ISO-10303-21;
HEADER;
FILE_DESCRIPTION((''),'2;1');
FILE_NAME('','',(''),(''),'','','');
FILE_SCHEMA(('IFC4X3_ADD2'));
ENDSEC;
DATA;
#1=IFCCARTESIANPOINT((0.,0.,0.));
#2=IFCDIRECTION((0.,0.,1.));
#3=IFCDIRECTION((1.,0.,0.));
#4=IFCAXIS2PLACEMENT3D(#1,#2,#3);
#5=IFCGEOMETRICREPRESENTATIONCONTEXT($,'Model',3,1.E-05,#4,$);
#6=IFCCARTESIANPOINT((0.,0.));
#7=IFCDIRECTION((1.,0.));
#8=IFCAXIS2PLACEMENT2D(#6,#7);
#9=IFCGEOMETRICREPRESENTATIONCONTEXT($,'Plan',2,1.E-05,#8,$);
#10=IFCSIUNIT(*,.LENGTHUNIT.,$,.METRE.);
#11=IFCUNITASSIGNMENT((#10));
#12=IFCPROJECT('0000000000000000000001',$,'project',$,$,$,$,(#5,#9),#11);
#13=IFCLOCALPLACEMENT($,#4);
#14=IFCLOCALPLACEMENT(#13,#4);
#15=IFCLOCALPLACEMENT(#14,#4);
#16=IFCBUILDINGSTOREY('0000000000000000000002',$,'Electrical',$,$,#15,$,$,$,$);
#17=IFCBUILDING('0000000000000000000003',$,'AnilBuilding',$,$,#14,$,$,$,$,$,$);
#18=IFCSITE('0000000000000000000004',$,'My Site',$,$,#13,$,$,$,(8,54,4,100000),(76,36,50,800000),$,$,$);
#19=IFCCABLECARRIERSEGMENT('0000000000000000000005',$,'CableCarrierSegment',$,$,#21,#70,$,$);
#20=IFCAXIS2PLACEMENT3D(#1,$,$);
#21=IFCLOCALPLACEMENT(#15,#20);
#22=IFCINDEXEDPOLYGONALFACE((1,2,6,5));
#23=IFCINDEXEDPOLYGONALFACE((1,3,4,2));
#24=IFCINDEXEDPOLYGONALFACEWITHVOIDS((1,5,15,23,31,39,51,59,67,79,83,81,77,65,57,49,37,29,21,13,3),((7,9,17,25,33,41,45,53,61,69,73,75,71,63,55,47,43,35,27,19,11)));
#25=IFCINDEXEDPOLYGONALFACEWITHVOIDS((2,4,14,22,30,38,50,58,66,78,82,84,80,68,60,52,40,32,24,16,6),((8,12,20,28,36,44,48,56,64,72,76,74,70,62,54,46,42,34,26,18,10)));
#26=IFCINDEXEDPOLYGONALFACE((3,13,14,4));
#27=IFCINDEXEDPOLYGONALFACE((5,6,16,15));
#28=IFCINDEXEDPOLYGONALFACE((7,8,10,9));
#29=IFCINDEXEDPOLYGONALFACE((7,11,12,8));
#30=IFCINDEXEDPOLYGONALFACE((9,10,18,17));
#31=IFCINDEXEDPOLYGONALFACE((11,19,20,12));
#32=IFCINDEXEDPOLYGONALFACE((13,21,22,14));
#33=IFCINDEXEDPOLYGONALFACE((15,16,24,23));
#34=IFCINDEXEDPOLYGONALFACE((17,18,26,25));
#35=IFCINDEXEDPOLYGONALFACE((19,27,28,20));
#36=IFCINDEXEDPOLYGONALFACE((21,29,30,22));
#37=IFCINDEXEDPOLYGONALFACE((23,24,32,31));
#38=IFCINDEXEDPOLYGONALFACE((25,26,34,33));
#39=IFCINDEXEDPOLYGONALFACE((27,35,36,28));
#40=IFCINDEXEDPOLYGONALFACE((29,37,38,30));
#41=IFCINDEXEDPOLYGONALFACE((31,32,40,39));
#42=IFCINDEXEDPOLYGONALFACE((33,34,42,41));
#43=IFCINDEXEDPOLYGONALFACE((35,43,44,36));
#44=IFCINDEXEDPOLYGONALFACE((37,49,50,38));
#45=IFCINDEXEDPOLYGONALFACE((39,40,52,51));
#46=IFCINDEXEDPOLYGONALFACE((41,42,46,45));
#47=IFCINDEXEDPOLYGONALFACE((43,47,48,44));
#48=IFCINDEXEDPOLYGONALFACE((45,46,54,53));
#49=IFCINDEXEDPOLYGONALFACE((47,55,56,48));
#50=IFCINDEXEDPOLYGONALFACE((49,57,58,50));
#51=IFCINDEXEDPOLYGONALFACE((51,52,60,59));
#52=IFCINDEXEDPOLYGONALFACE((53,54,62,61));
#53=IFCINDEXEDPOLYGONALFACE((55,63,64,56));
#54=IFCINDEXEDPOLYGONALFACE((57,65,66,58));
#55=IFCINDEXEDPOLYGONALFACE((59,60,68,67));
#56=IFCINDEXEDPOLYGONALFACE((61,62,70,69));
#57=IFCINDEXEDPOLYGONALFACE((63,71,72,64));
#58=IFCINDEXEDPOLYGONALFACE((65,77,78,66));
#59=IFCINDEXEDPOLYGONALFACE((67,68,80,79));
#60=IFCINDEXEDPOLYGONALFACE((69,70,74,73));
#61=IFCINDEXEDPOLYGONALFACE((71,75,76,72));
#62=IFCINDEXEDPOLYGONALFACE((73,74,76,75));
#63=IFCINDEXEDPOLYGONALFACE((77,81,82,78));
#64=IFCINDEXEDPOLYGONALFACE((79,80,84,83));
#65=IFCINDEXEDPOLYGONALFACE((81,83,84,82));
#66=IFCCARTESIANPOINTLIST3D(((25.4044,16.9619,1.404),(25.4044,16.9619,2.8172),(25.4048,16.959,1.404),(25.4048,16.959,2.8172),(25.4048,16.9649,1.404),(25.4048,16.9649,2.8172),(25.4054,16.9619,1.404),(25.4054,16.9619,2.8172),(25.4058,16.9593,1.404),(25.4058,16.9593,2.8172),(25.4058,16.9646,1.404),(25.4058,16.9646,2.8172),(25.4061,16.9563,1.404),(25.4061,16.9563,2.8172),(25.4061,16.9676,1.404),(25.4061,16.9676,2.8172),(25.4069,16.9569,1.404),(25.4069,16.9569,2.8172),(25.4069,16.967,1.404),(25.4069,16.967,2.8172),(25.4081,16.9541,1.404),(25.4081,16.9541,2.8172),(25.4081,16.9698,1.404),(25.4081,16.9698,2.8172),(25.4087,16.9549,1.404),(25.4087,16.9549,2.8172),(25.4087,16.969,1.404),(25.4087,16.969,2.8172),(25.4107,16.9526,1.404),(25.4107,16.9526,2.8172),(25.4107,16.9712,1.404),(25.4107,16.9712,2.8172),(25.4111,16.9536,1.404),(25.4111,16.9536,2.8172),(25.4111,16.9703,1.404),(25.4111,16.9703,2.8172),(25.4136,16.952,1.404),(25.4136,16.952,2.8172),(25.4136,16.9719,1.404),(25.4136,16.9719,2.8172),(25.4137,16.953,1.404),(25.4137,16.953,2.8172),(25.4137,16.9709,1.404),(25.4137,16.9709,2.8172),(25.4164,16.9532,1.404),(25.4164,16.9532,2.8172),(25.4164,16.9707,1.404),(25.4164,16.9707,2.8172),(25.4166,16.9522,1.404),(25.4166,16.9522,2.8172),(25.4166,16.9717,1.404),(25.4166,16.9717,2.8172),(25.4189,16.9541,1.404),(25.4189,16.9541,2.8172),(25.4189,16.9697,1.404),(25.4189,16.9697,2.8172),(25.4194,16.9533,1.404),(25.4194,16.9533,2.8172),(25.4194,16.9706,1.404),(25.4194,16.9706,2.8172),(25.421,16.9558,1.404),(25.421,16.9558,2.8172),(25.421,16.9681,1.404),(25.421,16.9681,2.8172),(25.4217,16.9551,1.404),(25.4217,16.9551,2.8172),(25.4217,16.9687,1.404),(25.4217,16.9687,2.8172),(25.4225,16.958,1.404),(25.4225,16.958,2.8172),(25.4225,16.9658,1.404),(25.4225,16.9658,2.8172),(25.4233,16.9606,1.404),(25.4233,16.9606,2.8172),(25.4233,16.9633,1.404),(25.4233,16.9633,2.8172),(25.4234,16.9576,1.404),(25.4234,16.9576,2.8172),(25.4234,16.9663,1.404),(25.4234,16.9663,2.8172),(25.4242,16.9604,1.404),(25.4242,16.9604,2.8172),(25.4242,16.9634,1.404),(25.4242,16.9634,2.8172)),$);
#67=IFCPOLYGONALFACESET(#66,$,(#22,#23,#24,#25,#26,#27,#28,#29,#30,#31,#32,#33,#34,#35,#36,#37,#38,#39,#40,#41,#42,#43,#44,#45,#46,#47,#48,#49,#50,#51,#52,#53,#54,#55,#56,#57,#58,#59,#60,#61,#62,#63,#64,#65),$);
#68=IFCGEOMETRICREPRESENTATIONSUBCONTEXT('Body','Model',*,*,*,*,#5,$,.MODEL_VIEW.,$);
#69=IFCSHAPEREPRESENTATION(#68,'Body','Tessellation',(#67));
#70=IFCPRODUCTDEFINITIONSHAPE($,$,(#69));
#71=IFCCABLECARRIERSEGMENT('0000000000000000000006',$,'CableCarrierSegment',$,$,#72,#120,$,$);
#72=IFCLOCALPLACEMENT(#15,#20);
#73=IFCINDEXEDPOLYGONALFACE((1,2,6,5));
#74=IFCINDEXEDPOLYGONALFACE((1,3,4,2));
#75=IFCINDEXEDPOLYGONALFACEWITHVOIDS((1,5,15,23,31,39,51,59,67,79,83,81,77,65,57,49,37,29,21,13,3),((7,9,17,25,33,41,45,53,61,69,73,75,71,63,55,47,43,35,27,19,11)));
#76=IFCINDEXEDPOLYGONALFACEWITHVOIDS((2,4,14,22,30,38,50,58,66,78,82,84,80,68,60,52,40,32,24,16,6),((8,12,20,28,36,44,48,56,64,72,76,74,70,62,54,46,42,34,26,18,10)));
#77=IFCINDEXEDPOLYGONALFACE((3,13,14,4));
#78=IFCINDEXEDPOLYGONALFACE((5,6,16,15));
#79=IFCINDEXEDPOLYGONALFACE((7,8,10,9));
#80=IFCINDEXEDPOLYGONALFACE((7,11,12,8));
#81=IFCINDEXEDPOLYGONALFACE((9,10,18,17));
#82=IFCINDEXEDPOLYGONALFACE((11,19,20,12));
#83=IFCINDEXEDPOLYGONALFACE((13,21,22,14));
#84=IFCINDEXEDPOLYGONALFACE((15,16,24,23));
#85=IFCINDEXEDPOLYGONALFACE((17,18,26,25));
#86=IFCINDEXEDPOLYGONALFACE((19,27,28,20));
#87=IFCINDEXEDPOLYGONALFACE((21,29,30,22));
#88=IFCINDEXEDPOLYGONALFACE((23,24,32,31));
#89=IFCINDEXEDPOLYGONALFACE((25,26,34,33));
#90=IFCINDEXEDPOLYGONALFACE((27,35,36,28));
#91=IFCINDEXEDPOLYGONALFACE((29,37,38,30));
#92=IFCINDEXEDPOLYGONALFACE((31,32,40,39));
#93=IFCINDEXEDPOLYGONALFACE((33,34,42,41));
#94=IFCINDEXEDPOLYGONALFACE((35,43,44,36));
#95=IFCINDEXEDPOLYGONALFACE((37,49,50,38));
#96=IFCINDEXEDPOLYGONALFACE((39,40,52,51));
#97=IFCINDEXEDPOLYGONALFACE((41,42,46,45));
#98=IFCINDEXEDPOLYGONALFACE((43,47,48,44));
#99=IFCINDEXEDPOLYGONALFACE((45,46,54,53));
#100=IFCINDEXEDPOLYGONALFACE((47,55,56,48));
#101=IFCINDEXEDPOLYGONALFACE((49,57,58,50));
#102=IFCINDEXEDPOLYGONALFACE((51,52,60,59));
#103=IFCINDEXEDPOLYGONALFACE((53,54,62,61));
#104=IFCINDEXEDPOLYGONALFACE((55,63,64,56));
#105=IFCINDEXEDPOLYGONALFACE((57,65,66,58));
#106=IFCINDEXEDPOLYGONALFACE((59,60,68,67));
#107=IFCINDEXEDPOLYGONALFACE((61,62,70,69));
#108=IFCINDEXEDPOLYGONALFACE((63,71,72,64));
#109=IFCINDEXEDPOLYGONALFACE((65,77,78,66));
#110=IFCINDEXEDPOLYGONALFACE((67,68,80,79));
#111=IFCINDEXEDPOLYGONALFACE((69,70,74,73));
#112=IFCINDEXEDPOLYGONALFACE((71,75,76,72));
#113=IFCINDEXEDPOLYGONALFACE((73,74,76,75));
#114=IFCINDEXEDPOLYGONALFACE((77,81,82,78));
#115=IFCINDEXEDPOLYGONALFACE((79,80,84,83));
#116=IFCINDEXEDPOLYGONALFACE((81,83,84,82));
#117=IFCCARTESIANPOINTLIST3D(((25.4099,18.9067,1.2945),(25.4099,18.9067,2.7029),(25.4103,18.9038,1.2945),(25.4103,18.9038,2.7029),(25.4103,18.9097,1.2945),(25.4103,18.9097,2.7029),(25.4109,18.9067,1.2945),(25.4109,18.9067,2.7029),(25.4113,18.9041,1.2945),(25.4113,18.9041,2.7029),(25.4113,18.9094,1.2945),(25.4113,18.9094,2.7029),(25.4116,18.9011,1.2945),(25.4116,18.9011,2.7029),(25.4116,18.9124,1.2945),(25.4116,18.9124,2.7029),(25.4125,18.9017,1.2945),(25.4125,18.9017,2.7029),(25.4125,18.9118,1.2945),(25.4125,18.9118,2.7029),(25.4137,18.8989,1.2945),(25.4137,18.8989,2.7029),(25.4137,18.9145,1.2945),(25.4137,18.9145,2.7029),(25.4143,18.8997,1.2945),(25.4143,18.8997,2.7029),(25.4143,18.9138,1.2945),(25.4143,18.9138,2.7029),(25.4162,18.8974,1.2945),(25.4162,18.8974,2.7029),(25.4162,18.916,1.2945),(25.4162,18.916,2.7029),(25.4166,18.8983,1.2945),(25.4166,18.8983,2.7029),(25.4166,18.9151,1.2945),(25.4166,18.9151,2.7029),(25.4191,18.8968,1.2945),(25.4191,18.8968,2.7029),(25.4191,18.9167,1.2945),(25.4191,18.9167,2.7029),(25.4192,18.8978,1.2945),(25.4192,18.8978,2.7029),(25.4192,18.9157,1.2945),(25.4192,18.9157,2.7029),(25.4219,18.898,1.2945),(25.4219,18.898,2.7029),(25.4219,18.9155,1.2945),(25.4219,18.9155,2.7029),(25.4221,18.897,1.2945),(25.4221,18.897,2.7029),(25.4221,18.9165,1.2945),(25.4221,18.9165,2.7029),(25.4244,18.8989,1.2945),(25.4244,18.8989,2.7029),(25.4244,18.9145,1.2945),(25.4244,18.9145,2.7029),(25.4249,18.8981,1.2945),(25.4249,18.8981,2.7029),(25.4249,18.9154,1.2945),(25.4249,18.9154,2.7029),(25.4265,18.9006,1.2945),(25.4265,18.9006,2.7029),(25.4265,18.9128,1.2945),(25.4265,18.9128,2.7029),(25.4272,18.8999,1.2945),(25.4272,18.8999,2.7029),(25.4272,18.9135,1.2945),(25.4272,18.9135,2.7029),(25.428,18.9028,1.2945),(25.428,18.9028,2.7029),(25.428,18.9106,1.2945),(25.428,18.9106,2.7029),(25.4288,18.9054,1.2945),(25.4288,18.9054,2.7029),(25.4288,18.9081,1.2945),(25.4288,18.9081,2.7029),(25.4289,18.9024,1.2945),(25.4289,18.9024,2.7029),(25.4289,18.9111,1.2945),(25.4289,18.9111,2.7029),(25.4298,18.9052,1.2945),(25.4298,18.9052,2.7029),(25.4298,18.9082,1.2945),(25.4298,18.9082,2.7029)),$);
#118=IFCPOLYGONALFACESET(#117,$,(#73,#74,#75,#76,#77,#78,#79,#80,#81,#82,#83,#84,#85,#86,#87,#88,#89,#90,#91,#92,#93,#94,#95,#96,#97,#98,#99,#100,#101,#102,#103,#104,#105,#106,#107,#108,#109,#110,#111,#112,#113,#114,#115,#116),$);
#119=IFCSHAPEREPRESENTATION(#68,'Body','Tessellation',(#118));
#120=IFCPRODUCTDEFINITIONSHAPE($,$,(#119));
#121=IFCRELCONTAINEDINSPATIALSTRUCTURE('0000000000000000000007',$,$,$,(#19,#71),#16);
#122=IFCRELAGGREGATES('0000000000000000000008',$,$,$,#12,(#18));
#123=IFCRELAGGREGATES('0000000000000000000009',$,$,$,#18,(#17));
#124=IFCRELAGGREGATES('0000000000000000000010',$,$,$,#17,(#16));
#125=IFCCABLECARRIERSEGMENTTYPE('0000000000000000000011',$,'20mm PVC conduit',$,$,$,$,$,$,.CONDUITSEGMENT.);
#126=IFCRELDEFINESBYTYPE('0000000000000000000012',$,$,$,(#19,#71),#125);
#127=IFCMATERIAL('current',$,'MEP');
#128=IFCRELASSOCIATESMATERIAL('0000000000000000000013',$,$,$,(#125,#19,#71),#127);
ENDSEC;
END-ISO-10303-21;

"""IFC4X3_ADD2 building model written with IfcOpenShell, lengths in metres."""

from ifc_helpers import new_model, si_unit, frame, origin_with_axes, origin_2d_with_axis, place, context, subcontext, project, spatial, hollow_circle, extrude, material, material_profile, profile_set, profile_usage, type_object, element, save


model = new_model("IFC4X3_ADD2")

# Units and contexts
model_context = context("Model", 3, precision=1e-05, world=origin_with_axes())
plan_context = context("Plan", 2, precision=1e-05, world=origin_2d_with_axis())
body_context = subcontext(model_context, "Body", "Model", "MODEL_VIEW")
ifc_project = project(units=[si_unit("LENGTHUNIT", "METRE")], contexts=[model_context, plan_context])

# Site, building, storey
site_placement = place(None, origin_with_axes())
site = spatial("IfcSite", under=ifc_project, at=site_placement, Name="My Site", RefLatitude=(8, 54, 4, 100000), RefLongitude=(76, 36, 50, 800000))
building_placement = place(site_placement, origin_with_axes())
building = spatial("IfcBuilding", under=site, at=building_placement, Name="AnilBuilding")
storey_placement = place(building_placement, origin_with_axes())
storey = spatial("IfcBuildingStorey", under=building, at=storey_placement, Name="Electrical")

# Cable carrier segments
ifc_material = material(Name="current", Category="MEP")
ifc_material_profile_1 = material_profile(ifc_material, hollow_circle(Radius=0.01, WallThickness=0.001))
ifc_profile_set_1 = profile_set([ifc_material_profile_1], Name="current")
ifc_material_profile_2 = material_profile(ifc_material, hollow_circle(Radius=0.01, WallThickness=0.001))
ifc_profile_set_2 = profile_set([ifc_material_profile_2], Name="current")
cable_carrier_segment_type = type_object("IfcCableCarrierSegmentType", Name="20mm PVC conduit", PredefinedType="CONDUITSEGMENT", material=ifc_profile_set_2)
ifc_profile_usage_1 = profile_usage(ifc_profile_set_1, cardinal=5)
cable_carrier_segment_1_placement = place(storey_placement, frame((25.4144, 16.9619, 1.404), z_axis=(0.0, 0.0, 1.0), x_axis=(-1.0, 0.0, 0.0)))
element("IfcCableCarrierSegment", 1, at=cable_carrier_segment_1_placement, inside=storey, type_object=cable_carrier_segment_type, material=ifc_profile_usage_1, Name="CableCarrierSegment", context=body_context, shape_type="SweptSolid", body=[
    extrude(hollow_circle(Radius=0.01, WallThickness=0.001), origin_with_axes(), (0.0, 0.0, 1.0), 1.4132),
])
ifc_profile_usage_2 = profile_usage(ifc_profile_set_1, cardinal=5)
cable_carrier_segment_2_placement = place(storey_placement, frame((25.4199, 18.9067, 1.2945), z_axis=(0.0, 0.0, 1.0), x_axis=(-1.0, 0.0, 0.0)))
element("IfcCableCarrierSegment", 2, at=cable_carrier_segment_2_placement, inside=storey, type_object=cable_carrier_segment_type, material=ifc_profile_usage_2, Name="CableCarrierSegment", context=body_context, shape_type="SweptSolid", body=[
    extrude(hollow_circle(Radius=0.01, WallThickness=0.001), origin_with_axes(), (0.0, 0.0, 1.0), 1.4084),
])

save(model, "model.ifc")
